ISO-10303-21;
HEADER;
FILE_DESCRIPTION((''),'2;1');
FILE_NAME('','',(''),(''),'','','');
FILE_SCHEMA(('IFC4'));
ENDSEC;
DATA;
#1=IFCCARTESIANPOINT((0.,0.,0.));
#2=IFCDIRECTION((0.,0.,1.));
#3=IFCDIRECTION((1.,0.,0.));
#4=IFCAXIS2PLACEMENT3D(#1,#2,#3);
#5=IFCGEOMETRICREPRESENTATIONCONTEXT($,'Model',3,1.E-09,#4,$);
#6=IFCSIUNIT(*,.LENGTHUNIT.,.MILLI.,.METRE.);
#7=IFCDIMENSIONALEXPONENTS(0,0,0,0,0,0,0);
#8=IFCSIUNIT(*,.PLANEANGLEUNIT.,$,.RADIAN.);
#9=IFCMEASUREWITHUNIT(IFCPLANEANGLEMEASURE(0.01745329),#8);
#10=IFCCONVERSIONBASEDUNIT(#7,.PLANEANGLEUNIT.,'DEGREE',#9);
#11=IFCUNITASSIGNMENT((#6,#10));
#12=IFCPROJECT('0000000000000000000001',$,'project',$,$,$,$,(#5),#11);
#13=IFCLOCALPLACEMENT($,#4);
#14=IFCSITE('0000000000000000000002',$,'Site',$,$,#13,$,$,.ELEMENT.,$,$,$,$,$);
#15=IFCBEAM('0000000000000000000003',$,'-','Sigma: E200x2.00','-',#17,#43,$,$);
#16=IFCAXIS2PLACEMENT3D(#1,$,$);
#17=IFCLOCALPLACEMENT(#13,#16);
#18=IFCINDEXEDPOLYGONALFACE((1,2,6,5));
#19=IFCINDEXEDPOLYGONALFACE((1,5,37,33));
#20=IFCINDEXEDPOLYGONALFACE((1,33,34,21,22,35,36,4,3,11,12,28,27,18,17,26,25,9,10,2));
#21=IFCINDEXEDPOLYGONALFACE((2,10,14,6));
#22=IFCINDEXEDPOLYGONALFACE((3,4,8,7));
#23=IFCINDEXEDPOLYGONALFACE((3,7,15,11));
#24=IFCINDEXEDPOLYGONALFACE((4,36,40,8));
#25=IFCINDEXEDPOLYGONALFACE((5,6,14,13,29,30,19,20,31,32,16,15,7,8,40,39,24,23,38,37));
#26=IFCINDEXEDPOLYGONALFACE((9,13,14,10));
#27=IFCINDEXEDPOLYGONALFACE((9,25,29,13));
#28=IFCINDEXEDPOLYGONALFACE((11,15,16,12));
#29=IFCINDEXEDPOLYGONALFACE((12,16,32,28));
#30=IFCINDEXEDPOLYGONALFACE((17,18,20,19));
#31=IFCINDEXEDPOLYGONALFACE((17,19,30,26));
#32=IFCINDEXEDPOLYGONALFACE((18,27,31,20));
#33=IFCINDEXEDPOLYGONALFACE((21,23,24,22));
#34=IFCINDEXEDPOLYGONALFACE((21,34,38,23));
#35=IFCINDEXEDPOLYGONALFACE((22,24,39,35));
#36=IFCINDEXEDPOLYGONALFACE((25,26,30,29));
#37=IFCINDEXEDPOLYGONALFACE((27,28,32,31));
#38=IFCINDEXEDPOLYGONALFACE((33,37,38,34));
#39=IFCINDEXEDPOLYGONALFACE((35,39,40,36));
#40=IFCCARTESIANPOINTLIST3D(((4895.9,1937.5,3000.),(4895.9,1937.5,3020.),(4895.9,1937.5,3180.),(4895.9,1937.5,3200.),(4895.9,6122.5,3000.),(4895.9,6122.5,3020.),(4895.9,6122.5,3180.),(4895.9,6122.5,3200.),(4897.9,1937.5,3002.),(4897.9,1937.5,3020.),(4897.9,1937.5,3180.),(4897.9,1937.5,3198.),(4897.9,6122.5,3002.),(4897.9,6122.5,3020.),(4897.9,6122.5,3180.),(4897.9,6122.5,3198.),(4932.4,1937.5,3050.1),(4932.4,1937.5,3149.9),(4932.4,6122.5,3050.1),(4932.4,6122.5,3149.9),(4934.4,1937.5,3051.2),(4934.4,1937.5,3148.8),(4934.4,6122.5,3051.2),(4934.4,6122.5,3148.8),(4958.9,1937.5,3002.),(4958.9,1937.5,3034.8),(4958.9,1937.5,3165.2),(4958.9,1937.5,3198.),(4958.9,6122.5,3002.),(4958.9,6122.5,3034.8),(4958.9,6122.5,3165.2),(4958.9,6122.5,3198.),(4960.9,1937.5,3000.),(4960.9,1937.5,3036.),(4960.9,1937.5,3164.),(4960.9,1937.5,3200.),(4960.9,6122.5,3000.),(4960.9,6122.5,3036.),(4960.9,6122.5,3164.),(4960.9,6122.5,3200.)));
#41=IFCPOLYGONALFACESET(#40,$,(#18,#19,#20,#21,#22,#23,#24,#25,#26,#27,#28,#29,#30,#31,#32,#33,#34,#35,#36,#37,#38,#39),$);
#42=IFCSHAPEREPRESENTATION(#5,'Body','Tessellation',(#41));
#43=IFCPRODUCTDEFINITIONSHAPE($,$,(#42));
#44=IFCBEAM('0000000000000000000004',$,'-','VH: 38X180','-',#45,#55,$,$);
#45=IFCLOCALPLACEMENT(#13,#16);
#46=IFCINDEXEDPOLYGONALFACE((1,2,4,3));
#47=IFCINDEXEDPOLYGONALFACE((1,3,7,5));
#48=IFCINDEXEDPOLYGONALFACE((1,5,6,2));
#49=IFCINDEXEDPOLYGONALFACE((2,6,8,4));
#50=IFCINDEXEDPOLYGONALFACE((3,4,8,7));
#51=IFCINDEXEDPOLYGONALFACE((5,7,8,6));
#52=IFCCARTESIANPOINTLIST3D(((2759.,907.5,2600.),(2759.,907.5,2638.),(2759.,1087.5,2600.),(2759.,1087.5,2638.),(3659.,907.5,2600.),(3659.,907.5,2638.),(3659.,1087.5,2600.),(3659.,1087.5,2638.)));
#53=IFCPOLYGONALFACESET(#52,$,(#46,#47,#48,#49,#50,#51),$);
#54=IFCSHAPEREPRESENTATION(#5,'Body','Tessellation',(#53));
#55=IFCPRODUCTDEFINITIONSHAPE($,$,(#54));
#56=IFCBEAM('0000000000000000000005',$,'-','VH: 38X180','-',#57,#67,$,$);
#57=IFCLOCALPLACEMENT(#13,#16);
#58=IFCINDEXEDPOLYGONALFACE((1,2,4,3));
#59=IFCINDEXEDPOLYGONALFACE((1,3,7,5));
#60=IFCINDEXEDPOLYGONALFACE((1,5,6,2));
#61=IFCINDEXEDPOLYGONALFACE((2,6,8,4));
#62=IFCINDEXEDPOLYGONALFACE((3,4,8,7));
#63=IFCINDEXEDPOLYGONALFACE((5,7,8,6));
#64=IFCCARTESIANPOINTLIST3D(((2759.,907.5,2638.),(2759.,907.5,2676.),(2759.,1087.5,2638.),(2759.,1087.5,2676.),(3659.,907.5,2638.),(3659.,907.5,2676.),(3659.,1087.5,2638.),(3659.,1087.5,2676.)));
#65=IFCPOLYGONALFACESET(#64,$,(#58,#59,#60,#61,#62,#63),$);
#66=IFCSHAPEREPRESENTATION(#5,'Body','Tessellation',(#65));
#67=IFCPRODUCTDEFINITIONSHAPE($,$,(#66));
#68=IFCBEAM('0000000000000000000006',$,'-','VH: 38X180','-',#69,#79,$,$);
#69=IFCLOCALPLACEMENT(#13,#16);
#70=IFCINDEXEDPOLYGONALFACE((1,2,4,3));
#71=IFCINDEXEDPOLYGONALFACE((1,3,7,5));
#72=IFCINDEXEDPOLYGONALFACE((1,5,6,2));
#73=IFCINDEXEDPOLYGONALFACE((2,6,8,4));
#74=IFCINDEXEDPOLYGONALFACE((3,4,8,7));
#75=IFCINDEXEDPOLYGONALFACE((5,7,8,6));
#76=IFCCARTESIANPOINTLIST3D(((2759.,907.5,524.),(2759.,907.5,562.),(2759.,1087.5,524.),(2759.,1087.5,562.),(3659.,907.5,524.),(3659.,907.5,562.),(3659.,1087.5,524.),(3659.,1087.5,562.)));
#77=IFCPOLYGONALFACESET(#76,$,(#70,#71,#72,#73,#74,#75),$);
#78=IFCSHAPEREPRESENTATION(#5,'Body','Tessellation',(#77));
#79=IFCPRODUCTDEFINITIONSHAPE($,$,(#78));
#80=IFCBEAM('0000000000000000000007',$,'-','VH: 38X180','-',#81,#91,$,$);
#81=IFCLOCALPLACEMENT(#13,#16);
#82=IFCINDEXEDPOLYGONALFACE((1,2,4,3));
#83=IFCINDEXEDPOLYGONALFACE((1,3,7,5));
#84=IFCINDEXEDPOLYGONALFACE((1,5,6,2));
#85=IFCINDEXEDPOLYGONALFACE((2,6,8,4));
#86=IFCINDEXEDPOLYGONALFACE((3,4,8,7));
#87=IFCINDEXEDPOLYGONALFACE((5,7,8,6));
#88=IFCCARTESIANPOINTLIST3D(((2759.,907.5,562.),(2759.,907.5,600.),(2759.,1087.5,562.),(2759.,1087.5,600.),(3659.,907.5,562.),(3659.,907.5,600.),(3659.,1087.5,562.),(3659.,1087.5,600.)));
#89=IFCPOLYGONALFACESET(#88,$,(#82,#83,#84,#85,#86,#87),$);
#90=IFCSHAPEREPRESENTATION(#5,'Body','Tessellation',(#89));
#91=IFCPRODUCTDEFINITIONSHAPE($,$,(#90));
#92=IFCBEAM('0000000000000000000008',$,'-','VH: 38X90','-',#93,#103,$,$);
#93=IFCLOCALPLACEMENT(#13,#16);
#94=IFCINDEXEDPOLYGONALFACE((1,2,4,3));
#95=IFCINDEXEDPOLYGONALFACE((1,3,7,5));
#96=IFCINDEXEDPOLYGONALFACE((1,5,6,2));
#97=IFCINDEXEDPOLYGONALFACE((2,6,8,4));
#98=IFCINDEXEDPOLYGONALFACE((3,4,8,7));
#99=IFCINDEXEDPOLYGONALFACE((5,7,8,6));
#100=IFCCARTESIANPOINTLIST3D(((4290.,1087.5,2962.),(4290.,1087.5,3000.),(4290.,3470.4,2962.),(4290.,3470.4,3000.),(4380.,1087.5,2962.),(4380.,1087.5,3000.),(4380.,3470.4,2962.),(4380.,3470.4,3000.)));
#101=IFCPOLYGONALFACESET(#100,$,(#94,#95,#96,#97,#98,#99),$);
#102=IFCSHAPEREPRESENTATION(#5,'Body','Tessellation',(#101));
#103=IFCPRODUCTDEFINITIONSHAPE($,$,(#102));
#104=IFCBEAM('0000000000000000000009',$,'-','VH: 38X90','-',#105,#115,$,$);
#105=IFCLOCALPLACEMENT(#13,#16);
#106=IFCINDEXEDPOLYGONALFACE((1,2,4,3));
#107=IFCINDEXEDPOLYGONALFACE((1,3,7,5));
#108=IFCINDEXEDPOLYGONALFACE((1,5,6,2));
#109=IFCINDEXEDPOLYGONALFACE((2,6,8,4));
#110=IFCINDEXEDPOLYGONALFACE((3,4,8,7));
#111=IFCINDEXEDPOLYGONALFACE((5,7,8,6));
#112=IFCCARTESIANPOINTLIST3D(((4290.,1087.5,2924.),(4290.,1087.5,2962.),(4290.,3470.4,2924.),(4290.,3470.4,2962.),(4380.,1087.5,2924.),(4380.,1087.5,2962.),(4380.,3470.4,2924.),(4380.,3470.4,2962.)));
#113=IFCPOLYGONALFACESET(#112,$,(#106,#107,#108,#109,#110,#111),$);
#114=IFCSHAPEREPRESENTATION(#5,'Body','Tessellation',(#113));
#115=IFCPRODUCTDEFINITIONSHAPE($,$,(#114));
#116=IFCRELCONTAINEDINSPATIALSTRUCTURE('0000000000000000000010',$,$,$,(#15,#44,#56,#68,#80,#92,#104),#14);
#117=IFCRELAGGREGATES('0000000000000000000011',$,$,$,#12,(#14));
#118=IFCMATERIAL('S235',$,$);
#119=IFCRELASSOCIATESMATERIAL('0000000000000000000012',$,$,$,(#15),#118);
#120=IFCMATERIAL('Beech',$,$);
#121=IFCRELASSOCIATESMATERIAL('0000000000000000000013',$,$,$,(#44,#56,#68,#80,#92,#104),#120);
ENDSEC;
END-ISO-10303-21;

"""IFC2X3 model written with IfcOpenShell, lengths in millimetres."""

from ifc_helpers import new_model, entity, si_unit, converted_unit, frame, origin, origin_with_axes, origin_2d, place, context, project, spatial, polyline, rectangle, outline, extrude, material, element, save


model = new_model("IFC2X3")

# Units and contexts
model_context = context("Model", 3, precision=1e-09, world=origin_with_axes())
ifc_project = project(units=[si_unit("LENGTHUNIT", "METRE", prefix="MILLI"), converted_unit("PLANEANGLEUNIT", "DEGREE", entity("IfcPlaneAngleMeasure", 0.01745329), si_unit("PLANEANGLEUNIT", "RADIAN"), dimensions=[0, 0, 0, 0, 0, 0, 0])], contexts=[model_context])

# Site
site_placement = place(None, origin_with_axes())
site = spatial("IfcSite", under=ifc_project, at=site_placement, Name="Site", CompositionType="ELEMENT")

# Shared definitions
ifc_material_1 = material(Name="Beech")

# Beams
ifc_material_2 = material(Name="S235")
beam_1_placement = place(None, frame((4935.0, 1937.5, 3100.0), z_axis=(0.0, 1.0, 0.0), x_axis=(-1.0, 0.0, 0.0)))
element("IfcBeam", 1, at=beam_1_placement, inside=site, material=ifc_material_2, Name="-", Description="Sigma: E200x2.00", ObjectType="-", context=model_context, shape_type="SweptSolid", body=[
    extrude(outline(polyline([(39.1, -100.0), (39.1, -80.0), (37.1, -80.0), (37.1, -98.0), (-23.9, -98.0), (-23.9, -65.2), (2.6, -49.9), (2.6, 49.9), (-23.9, 65.2), (-23.9, 98.0), (37.1, 98.0), (37.1, 80.0), (39.1, 80.0), (39.1, 100.0), (-25.9, 100.0), (-25.9, 64.0), (0.6, 48.8), (0.6, -48.8), (-25.9, -64.0), (-25.9, -100.0), (39.1, -100.0)])), origin(), (0.0, 0.0, 1.0), 4185.0),
])
for number, where, z_axis, x_axis, name in (
    (2, (2759.0, 997.5, 2619.0), (-1.0, 0.0, 0.0), (0.0, 0.0, -1.0), "-"),
    (3, (2759.0, 997.5, 2657.0), (-1.0, 0.0, 0.0), (0.0, 0.0, -1.0), "-"),
    (4, (2759.0, 997.5, 543.0), (-1.0, 0.0, 0.0), (0.0, 0.0, -1.0), "-"),
    (5, (2759.0, 997.5, 581.0), (-1.0, 0.0, 0.0), (0.0, 0.0, -1.0), "-"),
):
    element("IfcBeam", number, at=place(None, frame(where, z_axis=z_axis, x_axis=x_axis)), inside=site, material=ifc_material_1, Name=name, Description="VH: 38X180", ObjectType="-", context=model_context, shape_type="SweptSolid", body=[
        extrude(rectangle(XDim=38.0, YDim=180.0, at=origin_2d()), origin(), (0.0, 0.0, -1.0), 900.0),
    ])
for number, where, z_axis, x_axis, name in (
    (6, (4335.0, 1087.5, 2981.0), (0.0, -1.0, 0.0), (0.0, 0.0, -1.0), "-"),
    (7, (4335.0, 1087.5, 2943.0), (0.0, -1.0, 0.0), (0.0, 0.0, -1.0), "-"),
):
    element("IfcBeam", number, at=place(None, frame(where, z_axis=z_axis, x_axis=x_axis)), inside=site, material=ifc_material_1, Name=name, Description="VH: 38X90", ObjectType="-", context=model_context, shape_type="SweptSolid", body=[
        extrude(rectangle(XDim=38.0, YDim=90.0, at=origin_2d()), origin(), (0.0, 0.0, -1.0), 2382.9),
    ])

save(model, "model.ifc")
